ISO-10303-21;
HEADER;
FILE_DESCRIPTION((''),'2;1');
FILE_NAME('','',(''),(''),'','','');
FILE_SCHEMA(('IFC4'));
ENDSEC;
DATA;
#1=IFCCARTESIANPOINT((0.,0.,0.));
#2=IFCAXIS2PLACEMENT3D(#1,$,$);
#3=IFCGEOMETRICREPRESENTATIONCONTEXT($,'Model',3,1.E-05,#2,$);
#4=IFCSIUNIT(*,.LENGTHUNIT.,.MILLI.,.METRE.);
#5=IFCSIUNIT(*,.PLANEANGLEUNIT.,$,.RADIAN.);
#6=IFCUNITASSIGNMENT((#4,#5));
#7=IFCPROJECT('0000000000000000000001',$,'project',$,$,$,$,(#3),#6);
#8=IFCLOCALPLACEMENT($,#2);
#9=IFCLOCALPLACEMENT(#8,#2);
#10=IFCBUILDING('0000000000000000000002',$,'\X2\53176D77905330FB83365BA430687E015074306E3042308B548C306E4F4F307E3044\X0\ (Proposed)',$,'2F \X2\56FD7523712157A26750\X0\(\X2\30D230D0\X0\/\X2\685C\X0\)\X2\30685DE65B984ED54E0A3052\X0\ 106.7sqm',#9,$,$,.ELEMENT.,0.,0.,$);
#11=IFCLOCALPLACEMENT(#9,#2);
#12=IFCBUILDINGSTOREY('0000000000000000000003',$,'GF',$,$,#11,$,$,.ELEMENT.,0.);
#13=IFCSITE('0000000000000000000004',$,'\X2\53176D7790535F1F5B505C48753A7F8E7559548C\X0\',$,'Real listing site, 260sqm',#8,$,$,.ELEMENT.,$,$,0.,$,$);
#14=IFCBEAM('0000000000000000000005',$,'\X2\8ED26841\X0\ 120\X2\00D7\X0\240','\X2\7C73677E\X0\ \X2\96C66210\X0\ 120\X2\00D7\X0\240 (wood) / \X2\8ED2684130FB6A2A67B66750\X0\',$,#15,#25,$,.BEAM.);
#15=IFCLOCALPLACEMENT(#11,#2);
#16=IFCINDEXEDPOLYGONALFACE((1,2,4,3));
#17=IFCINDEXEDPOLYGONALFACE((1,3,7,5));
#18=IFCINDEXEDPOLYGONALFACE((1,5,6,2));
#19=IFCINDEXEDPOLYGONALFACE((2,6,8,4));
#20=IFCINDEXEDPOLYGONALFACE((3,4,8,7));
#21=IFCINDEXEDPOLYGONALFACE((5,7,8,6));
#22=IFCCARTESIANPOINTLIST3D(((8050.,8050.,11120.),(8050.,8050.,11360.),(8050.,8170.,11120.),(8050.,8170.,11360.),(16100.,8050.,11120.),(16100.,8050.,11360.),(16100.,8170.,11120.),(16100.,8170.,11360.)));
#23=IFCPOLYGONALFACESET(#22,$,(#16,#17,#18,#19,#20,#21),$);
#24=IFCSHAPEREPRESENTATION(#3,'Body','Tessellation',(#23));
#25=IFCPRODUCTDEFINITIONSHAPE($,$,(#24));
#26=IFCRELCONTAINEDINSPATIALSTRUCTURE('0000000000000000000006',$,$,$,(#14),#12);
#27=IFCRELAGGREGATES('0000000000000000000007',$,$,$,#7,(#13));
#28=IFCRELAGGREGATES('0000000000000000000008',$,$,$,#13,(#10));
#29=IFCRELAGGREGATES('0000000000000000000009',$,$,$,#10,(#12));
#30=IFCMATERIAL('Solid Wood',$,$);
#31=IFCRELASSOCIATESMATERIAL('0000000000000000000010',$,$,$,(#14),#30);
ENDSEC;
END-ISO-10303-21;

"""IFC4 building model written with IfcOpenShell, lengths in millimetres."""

from ifc_helpers import new_model, si_unit, frame, frame_2d, origin, place, context, project, spatial, rectangle, extrude, material, element, save


model = new_model("IFC4")

# Units and contexts
model_context = context("Model", 3, precision=1e-05, world=origin())
ifc_project = project(units=[si_unit("LENGTHUNIT", "METRE", prefix="MILLI"), si_unit("PLANEANGLEUNIT", "RADIAN")], contexts=[model_context])

# Site, building, storey
site_placement = place(None, origin())
site = spatial("IfcSite", under=ifc_project, at=site_placement, Name="北海道弟子屈町美留和", ObjectType="Real listing site, 260sqm", CompositionType="ELEMENT", RefElevation=0.0)
building_placement = place(site_placement, origin())
building = spatial("IfcBuilding", under=site, at=building_placement, Name="北海道・茶室と縁側のある和の住まい (Proposed)", ObjectType="2F 国産無垢材(ヒバ/桜)と左官仕上げ 106.7sqm", CompositionType="ELEMENT", ElevationOfRefHeight=0.0, ElevationOfTerrain=0.0)
storey_placement = place(building_placement, origin())
storey = spatial("IfcBuildingStorey", under=building, at=storey_placement, Name="GF", CompositionType="ELEMENT", Elevation=0.0)

# Shared definitions
ifc_material_1 = material(Name="Solid Wood")

# Beam
beam_1_placement = place(storey_placement, frame((4025.0, 4025.0, 5560.0)))
element("IfcBeam", 1, at=beam_1_placement, inside=storey, material=ifc_material_1, Name="軒桁 120×240", Description="米松 集成 120×240 (wood) / 軒桁・横架材", PredefinedType="BEAM", context=model_context, shape_type="SweptSolid", body=[
    extrude(rectangle(XDim=8050.0, YDim=120.0, at=frame_2d((4025.0, 60.0))), frame((4025.0, 4025.0, 5560.0)), (0.0, 0.0, 1.0), 240.0),
])

save(model, "model.ifc")
